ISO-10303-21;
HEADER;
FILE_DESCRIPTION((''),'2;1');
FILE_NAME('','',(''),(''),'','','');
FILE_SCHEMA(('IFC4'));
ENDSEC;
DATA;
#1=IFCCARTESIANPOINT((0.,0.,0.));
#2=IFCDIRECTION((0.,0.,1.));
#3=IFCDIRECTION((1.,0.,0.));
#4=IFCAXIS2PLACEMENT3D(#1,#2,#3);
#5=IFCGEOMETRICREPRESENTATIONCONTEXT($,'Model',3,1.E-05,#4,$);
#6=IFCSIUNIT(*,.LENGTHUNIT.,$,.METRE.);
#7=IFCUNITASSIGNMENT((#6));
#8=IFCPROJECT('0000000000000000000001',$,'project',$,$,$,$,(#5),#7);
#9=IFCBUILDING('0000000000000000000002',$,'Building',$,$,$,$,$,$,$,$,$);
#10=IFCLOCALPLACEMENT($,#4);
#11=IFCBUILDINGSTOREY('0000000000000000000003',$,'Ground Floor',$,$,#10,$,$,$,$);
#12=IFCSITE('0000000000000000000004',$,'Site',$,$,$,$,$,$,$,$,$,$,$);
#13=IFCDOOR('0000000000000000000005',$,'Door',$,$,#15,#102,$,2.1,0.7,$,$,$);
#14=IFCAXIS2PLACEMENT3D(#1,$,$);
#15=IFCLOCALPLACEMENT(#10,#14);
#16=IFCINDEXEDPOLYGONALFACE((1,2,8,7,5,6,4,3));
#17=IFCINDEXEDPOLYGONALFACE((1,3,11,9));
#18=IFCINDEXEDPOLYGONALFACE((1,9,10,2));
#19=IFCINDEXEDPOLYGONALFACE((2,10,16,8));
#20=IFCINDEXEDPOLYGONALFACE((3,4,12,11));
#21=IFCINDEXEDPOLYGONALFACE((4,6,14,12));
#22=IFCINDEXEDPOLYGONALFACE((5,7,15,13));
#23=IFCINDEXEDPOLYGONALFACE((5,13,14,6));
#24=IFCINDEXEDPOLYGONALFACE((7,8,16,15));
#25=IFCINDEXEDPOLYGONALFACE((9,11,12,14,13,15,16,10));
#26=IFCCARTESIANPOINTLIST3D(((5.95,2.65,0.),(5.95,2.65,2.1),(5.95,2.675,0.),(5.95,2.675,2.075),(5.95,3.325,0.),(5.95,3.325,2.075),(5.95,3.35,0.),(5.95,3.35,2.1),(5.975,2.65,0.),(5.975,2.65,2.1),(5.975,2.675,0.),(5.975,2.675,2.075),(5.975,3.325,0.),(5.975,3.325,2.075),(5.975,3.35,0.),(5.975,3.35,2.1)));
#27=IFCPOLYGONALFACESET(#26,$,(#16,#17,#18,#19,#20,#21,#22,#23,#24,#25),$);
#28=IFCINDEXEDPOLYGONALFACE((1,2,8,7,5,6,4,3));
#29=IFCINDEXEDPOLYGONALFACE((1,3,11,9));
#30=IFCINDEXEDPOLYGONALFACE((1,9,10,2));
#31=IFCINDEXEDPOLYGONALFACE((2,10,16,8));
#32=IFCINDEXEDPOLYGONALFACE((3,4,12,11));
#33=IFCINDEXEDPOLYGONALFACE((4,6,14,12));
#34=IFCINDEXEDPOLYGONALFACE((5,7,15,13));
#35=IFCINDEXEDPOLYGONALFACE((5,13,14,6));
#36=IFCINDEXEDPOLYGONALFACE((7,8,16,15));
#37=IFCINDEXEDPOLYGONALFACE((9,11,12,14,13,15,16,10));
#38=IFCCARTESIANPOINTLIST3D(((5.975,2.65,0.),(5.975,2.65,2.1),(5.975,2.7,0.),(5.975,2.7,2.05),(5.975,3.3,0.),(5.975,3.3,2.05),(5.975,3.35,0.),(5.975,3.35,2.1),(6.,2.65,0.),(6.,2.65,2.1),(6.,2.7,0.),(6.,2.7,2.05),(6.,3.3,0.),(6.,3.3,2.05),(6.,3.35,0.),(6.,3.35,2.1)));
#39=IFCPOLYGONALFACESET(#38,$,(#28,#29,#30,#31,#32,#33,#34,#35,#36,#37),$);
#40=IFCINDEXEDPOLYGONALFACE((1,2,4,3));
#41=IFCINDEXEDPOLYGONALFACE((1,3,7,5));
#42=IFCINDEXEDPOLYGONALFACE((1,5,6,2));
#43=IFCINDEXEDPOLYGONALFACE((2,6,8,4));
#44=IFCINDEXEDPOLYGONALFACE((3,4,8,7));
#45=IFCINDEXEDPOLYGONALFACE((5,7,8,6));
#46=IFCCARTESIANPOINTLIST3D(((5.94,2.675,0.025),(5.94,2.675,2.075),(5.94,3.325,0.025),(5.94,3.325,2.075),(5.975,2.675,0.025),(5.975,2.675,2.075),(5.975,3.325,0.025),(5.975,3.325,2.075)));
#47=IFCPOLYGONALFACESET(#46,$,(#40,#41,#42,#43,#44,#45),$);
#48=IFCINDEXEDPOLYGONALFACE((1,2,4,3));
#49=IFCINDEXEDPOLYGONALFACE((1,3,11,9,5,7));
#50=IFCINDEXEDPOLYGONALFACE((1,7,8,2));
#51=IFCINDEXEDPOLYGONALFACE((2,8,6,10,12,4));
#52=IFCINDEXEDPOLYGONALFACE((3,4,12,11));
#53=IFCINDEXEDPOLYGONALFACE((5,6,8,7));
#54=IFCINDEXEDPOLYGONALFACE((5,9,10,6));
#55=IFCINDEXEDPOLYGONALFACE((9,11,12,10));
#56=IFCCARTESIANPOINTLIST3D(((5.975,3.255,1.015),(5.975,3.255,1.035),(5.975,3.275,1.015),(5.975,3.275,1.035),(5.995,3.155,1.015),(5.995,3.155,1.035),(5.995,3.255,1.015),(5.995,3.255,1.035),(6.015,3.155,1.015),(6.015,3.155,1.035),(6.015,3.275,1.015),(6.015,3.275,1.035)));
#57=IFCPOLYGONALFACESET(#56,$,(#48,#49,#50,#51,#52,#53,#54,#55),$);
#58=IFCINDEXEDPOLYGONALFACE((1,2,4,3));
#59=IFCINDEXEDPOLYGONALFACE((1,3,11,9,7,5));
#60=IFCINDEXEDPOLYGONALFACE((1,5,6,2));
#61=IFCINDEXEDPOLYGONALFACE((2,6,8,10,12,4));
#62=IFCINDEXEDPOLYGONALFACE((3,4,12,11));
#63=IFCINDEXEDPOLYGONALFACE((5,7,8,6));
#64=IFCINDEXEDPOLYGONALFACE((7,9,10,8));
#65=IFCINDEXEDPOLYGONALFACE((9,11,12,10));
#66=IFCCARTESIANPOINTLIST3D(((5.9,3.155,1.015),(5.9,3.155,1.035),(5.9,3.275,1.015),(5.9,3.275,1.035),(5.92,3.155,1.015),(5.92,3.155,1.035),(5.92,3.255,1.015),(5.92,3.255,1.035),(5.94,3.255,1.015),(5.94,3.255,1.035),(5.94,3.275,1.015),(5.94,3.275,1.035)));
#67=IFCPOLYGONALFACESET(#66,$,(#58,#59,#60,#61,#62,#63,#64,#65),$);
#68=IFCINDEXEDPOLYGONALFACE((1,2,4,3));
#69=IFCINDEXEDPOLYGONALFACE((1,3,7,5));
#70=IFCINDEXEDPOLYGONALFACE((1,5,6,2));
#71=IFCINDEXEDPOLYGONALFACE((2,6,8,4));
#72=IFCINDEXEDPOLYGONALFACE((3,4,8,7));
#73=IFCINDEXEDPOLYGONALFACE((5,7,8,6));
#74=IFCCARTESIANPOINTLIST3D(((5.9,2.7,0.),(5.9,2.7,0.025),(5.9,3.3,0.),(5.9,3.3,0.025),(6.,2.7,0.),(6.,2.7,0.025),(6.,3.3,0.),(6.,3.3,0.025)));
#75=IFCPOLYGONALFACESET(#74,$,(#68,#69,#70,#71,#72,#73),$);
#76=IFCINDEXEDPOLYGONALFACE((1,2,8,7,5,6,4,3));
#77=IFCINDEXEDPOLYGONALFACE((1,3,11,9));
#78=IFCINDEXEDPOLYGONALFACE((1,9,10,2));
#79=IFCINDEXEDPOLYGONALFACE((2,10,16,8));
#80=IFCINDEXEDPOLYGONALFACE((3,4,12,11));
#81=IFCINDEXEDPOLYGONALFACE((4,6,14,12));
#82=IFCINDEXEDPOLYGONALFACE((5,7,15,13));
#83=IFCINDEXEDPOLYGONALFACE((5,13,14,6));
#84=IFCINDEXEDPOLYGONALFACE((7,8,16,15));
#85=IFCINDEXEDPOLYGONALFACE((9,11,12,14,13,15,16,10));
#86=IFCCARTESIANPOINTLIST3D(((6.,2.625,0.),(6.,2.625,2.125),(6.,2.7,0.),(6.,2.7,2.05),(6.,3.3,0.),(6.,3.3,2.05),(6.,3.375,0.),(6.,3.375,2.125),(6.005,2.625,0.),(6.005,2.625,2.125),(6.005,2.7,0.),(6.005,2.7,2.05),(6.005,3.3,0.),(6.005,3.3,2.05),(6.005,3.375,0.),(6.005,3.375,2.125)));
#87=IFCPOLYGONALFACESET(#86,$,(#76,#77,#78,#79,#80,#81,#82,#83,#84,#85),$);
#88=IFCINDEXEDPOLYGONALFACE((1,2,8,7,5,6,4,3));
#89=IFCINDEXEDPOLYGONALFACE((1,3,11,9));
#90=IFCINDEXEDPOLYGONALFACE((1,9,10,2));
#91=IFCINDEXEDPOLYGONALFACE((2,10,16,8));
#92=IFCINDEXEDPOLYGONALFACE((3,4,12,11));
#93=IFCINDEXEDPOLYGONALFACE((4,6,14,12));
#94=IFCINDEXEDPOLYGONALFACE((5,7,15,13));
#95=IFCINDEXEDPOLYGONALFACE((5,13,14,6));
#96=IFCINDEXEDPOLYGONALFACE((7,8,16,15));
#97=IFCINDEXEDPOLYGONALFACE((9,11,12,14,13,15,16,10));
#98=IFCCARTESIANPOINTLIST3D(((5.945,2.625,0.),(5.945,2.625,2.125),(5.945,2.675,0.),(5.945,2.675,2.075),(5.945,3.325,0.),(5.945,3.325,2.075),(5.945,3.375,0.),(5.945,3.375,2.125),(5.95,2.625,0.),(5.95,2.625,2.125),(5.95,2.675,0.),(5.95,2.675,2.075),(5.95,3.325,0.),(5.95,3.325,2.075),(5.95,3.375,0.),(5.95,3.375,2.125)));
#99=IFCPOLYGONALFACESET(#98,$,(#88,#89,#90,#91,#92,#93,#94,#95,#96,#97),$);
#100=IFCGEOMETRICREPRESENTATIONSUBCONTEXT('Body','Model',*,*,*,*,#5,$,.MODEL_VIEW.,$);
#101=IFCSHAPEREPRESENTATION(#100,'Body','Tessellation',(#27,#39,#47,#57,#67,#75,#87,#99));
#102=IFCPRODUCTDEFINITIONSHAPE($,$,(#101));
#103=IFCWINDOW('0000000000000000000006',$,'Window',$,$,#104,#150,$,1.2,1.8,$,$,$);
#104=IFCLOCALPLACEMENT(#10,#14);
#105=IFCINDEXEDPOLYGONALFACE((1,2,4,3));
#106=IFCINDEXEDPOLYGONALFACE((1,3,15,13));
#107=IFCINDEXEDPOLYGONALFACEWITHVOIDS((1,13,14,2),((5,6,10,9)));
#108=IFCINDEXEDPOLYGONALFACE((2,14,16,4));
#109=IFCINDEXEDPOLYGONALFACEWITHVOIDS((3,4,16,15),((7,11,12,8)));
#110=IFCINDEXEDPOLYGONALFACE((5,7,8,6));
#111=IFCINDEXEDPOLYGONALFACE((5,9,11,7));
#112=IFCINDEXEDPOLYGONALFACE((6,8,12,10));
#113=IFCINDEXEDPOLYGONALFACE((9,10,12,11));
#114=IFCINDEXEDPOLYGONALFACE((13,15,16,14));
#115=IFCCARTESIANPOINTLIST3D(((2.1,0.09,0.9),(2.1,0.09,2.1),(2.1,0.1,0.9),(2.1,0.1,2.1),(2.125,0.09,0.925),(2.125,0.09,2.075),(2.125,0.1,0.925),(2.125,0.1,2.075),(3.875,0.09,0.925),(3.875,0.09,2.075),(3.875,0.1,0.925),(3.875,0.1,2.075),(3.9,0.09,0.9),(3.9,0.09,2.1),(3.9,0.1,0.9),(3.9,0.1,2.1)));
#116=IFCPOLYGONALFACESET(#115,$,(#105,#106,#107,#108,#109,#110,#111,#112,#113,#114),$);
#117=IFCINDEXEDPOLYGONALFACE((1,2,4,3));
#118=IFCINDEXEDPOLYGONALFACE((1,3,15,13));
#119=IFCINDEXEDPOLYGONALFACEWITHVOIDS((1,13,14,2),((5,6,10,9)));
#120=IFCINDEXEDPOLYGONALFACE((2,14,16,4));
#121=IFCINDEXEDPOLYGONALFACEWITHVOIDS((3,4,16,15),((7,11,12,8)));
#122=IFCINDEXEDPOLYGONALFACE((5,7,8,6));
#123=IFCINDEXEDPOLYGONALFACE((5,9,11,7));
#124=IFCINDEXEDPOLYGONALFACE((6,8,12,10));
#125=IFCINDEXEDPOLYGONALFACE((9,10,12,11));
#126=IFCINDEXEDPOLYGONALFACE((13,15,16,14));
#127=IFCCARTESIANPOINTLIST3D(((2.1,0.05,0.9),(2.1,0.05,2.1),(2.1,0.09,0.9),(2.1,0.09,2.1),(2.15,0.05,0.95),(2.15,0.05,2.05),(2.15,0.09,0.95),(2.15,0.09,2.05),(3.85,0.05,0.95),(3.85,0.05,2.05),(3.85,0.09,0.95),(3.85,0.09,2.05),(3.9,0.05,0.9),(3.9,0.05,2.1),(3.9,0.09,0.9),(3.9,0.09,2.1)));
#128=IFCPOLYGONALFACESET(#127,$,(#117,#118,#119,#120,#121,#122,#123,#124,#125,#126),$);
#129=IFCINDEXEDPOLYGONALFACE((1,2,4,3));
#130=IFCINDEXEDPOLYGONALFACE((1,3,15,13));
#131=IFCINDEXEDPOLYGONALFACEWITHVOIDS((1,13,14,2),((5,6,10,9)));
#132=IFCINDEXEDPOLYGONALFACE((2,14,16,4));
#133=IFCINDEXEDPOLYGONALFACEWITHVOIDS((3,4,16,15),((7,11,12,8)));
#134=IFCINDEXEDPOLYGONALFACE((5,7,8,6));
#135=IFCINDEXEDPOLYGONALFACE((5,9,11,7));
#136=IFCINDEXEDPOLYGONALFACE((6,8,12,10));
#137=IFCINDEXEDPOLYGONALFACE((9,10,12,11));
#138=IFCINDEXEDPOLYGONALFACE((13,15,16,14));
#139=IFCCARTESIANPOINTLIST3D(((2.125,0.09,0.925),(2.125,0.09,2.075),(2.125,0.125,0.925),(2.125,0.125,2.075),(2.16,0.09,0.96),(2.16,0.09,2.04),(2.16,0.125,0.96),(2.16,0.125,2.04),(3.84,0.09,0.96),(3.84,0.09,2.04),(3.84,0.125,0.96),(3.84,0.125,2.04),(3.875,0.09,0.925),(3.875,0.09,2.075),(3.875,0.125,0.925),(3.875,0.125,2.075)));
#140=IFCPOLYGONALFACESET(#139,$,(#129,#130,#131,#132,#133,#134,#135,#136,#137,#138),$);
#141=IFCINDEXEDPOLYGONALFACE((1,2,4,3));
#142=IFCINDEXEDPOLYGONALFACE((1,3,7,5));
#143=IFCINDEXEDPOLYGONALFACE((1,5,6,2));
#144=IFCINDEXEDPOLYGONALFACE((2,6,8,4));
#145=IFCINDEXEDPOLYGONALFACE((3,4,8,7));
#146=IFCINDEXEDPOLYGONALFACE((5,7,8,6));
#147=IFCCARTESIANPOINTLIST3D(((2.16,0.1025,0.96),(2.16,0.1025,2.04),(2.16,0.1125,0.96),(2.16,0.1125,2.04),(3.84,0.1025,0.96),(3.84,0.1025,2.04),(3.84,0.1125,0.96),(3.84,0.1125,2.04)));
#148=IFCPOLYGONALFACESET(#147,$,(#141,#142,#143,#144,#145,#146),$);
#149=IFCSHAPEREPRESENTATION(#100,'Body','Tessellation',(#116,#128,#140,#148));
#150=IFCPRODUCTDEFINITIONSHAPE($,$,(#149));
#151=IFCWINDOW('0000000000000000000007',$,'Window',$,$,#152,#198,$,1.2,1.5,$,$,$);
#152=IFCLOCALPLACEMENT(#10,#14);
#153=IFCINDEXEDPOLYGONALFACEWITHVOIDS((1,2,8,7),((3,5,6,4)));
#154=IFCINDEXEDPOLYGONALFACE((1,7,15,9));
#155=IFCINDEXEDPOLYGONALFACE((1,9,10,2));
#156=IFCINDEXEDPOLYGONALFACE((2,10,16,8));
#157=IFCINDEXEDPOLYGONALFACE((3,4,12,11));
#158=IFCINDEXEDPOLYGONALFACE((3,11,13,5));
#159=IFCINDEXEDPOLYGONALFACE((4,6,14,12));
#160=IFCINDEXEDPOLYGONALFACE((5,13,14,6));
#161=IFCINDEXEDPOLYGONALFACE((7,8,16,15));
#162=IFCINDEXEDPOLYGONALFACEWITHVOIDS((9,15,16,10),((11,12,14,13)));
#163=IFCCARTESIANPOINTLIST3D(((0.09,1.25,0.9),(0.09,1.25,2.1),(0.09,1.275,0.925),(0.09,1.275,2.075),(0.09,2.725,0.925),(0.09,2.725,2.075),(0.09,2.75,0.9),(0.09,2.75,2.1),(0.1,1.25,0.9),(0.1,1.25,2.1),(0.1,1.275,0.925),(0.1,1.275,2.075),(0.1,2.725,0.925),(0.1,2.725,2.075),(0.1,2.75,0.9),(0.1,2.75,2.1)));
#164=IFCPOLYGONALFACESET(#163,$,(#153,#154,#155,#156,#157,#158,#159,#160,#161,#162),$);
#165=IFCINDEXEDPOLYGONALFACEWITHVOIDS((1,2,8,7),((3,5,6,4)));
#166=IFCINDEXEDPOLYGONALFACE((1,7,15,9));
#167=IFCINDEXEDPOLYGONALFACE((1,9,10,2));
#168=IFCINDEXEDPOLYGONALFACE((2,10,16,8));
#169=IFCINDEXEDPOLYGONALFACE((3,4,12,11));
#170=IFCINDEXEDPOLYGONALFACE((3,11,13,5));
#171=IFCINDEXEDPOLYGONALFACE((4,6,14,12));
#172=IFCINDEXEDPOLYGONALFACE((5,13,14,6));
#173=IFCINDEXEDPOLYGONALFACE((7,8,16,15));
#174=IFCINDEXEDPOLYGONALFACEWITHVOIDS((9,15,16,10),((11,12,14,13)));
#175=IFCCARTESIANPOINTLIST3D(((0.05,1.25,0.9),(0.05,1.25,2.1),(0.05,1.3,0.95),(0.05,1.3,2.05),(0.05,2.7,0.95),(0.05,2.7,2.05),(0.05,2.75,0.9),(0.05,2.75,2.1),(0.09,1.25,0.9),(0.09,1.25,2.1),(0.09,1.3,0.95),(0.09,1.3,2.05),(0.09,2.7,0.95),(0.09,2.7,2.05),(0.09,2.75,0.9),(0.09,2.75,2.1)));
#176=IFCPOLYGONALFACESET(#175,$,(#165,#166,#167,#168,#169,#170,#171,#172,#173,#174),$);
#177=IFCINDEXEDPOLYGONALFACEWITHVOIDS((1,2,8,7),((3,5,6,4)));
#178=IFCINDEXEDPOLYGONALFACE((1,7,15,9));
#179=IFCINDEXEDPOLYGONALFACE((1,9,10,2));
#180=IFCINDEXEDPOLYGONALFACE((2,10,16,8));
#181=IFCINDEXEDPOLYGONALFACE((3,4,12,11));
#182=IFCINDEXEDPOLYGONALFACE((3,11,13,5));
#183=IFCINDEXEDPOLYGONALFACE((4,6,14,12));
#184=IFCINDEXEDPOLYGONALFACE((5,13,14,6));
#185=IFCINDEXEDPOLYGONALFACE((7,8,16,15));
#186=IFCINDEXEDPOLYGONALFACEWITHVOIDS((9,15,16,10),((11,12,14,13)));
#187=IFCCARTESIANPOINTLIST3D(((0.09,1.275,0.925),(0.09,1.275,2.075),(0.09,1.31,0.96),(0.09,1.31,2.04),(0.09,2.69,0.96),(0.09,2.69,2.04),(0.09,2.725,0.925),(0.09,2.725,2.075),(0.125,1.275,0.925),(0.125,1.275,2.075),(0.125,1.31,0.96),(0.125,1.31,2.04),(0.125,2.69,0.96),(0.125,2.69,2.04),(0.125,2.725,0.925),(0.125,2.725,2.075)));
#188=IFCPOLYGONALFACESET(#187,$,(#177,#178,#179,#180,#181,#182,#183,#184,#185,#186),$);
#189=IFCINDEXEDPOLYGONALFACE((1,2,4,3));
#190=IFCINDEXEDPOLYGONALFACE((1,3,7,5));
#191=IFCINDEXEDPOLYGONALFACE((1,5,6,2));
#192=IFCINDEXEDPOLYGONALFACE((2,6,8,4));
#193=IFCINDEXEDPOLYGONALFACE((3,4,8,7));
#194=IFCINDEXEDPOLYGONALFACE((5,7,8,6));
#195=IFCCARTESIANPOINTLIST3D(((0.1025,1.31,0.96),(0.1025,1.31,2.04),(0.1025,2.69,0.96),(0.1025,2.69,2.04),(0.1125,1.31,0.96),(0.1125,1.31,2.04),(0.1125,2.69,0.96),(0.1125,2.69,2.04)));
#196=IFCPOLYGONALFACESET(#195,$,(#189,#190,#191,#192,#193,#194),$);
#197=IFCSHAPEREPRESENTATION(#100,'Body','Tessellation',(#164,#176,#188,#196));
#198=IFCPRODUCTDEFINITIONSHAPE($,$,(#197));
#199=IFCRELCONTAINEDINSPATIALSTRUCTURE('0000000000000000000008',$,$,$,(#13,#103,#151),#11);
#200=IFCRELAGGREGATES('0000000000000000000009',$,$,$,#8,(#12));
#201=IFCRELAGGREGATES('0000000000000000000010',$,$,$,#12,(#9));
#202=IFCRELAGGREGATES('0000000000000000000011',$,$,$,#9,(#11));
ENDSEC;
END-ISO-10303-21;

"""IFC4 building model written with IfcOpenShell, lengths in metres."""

from ifc_helpers import new_model, si_unit, frame, origin_with_axes, place, context, subcontext, project, spatial, line, indexed_curve, outline, extrude, element, save


model = new_model("IFC4")

# Units and contexts
model_context = context("Model", 3, precision=1e-05, world=origin_with_axes())
body_context = subcontext(model_context, "Body", "Model", "MODEL_VIEW")
ifc_project = project(units=[si_unit("LENGTHUNIT", "METRE")], contexts=[model_context])

# Site, building, storey
site = spatial("IfcSite", under=ifc_project, Name="Site")
building = spatial("IfcBuilding", under=site, Name="Building")
storey_placement = place(None, origin_with_axes())
storey = spatial("IfcBuildingStorey", under=building, at=storey_placement, Name="Ground Floor")

# Door
door_1_placement = place(storey_placement, frame((6.0, 2.65, 0.0), z_axis=(0.0, 0.0, 1.0), x_axis=(0.0, 1.0, 0.0)))
element("IfcDoor", 1, at=door_1_placement, inside=storey, Name="Door", OverallHeight=2.1, OverallWidth=0.7, context=body_context, shape_type="SweptSolid", body=[
    extrude(outline(indexed_curve([(0.0, 0.0), (0.0, 2.1), (0.7, 2.1), (0.7, 0.0), (0.675, 0.0), (0.675, 2.075), (0.025, 2.075), (0.025, 0.0)], segments=[line(1, 2, 3, 4, 5, 6, 7, 8, 1)])), frame((0.0, 0.025, 0.0), z_axis=(0.0, -1.0, 0.0), x_axis=(1.0, 0.0, 0.0)), (0.0, 0.0, -1.0), 0.025),
    extrude(outline(indexed_curve([(0.0, 0.0), (0.0, 2.1), (0.7, 2.1), (0.7, 0.0), (0.65, 0.0), (0.65, 2.05), (0.05, 2.05), (0.05, 0.0)], segments=[line(1, 2, 3, 4, 5, 6, 7, 8, 1)])), frame((0.0, 0.0, 0.0), z_axis=(0.0, -1.0, 0.0), x_axis=(1.0, 0.0, 0.0)), (0.0, 0.0, -1.0), 0.025),
    extrude(outline(indexed_curve([(0.0, 0.0), (0.65, 0.0), (0.65, 0.035), (0.0, 0.035)], segments=[line(1, 2, 3, 4, 1)])), frame((0.025, 0.025, 0.025), z_axis=(0.0, 0.0, 1.0), x_axis=(1.0, 0.0, 0.0)), (0.0, 0.0, 1.0), 2.05),
    extrude(outline(indexed_curve([(0.0, 0.0), (0.0, -0.04), (-0.12, -0.04), (-0.12, -0.02), (-0.02, -0.02), (-0.02, 0.0)], segments=[line(1, 2, 3, 4, 5, 6, 1)])), frame((0.625, 0.025, 1.015), z_axis=(0.0, 0.0, 1.0), x_axis=(1.0, 0.0, 0.0)), (0.0, 0.0, 1.0), 0.02),
    extrude(outline(indexed_curve([(0.0, 0.0), (0.0, 0.04), (-0.12, 0.04), (-0.12, 0.02), (-0.02, 0.02), (-0.02, 0.0)], segments=[line(1, 2, 3, 4, 5, 6, 1)])), frame((0.625, 0.06, 1.015), z_axis=(0.0, 0.0, 1.0), x_axis=(1.0, 0.0, 0.0)), (0.0, 0.0, 1.0), 0.02),
    extrude(outline(indexed_curve([(0.0, 0.0), (0.6, 0.0), (0.6, 0.1), (0.0, 0.1)], segments=[line(1, 2, 3, 4, 1)])), frame((0.05, 0.0, 0.0), z_axis=(0.0, 0.0, 1.0), x_axis=(1.0, 0.0, 0.0)), (0.0, 0.0, 1.0), 0.025),
    extrude(outline(indexed_curve([(0.0, 0.0), (0.0, 2.125), (0.75, 2.125), (0.75, 0.0), (0.675, 0.0), (0.675, 2.05), (0.075, 2.05), (0.075, 0.0)], segments=[line(1, 2, 3, 4, 5, 6, 7, 8, 1)])), frame((-0.025, -0.005, 0.0), z_axis=(0.0, -1.0, 0.0), x_axis=(1.0, 0.0, 0.0)), (0.0, 0.0, -1.0), 0.005),
    extrude(outline(indexed_curve([(0.0, 0.0), (0.0, 2.125), (0.75, 2.125), (0.75, 0.0), (0.7, 0.0), (0.7, 2.075), (0.05, 2.075), (0.05, 0.0)], segments=[line(1, 2, 3, 4, 5, 6, 7, 8, 1)])), frame((-0.025, 0.05, 0.0), z_axis=(0.0, -1.0, 0.0), x_axis=(1.0, 0.0, 0.0)), (0.0, 0.0, -1.0), 0.005),
])

# Windows
window_1_placement = place(storey_placement, frame((2.1, 0.0, 0.9), z_axis=(0.0, 0.0, 1.0), x_axis=(1.0, 0.0, 0.0)))
element("IfcWindow", 2, at=window_1_placement, inside=storey, Name="Window", OverallHeight=1.2, OverallWidth=1.8, context=body_context, shape_type="SweptSolid", body=[
    extrude(outline(indexed_curve([(0.0, 0.0), (1.8, 0.0), (1.8, 1.2), (0.0, 1.2)], segments=[line(1, 2, 3, 4, 1)]), holes=[indexed_curve([(0.025, 0.025), (1.775, 0.025), (1.775, 1.175), (0.025, 1.175)], segments=[line(1, 2, 3, 4, 1)])]), frame((0.0, 0.09, 0.0), z_axis=(0.0, -1.0, 0.0), x_axis=(1.0, 0.0, 0.0)), (0.0, 0.0, -1.0), 0.01),
    extrude(outline(indexed_curve([(0.0, 0.0), (1.8, 0.0), (1.8, 1.2), (0.0, 1.2)], segments=[line(1, 2, 3, 4, 1)]), holes=[indexed_curve([(0.05, 0.05), (1.75, 0.05), (1.75, 1.15), (0.05, 1.15)], segments=[line(1, 2, 3, 4, 1)])]), frame((0.0, 0.05, 0.0), z_axis=(0.0, -1.0, 0.0), x_axis=(1.0, 0.0, 0.0)), (0.0, 0.0, -1.0), 0.04),
    extrude(outline(indexed_curve([(0.0, 0.0), (1.75, 0.0), (1.75, 1.15), (0.0, 1.15)], segments=[line(1, 2, 3, 4, 1)]), holes=[indexed_curve([(0.035, 0.035), (1.715, 0.035), (1.715, 1.115), (0.035, 1.115)], segments=[line(1, 2, 3, 4, 1)])]), frame((0.025, 0.09, 0.025), z_axis=(0.0, -1.0, 0.0), x_axis=(1.0, 0.0, 0.0)), (0.0, 0.0, -1.0), 0.035),
    extrude(outline(indexed_curve([(0.035, 0.035), (1.715, 0.035), (1.715, 1.115), (0.035, 1.115)], segments=[line(1, 2, 3, 4, 1)])), frame((0.025, 0.1025, 0.025), z_axis=(0.0, -1.0, 0.0), x_axis=(1.0, 0.0, 0.0)), (0.0, 0.0, -1.0), 0.01),
])
for number, where, z_axis, x_axis, name in (
    (3, (0.0, 2.75, 0.9), (0.0, 0.0, 1.0), (0.0, -1.0, 0.0), "Window"),
):
    element("IfcWindow", number, at=place(storey_placement, frame(where, z_axis=z_axis, x_axis=x_axis)), inside=storey, Name=name, OverallHeight=1.2, OverallWidth=1.5, context=body_context, shape_type="SweptSolid", body=[
        extrude(outline(indexed_curve([(0.0, 0.0), (1.5, 0.0), (1.5, 1.2), (0.0, 1.2)], segments=[line(1, 2, 3, 4, 1)]), holes=[indexed_curve([(0.025, 0.025), (1.475, 0.025), (1.475, 1.175), (0.025, 1.175)], segments=[line(1, 2, 3, 4, 1)])]), frame((0.0, 0.09, 0.0), z_axis=(0.0, -1.0, 0.0), x_axis=(1.0, 0.0, 0.0)), (0.0, 0.0, -1.0), 0.01),
        extrude(outline(indexed_curve([(0.0, 0.0), (1.5, 0.0), (1.5, 1.2), (0.0, 1.2)], segments=[line(1, 2, 3, 4, 1)]), holes=[indexed_curve([(0.05, 0.05), (1.45, 0.05), (1.45, 1.15), (0.05, 1.15)], segments=[line(1, 2, 3, 4, 1)])]), frame((0.0, 0.05, 0.0), z_axis=(0.0, -1.0, 0.0), x_axis=(1.0, 0.0, 0.0)), (0.0, 0.0, -1.0), 0.04),
        extrude(outline(indexed_curve([(0.0, 0.0), (1.45, 0.0), (1.45, 1.15), (0.0, 1.15)], segments=[line(1, 2, 3, 4, 1)]), holes=[indexed_curve([(0.035, 0.035), (1.415, 0.035), (1.415, 1.115), (0.035, 1.115)], segments=[line(1, 2, 3, 4, 1)])]), frame((0.025, 0.09, 0.025), z_axis=(0.0, -1.0, 0.0), x_axis=(1.0, 0.0, 0.0)), (0.0, 0.0, -1.0), 0.035),
        extrude(outline(indexed_curve([(0.035, 0.035), (1.415, 0.035), (1.415, 1.115), (0.035, 1.115)], segments=[line(1, 2, 3, 4, 1)])), frame((0.025, 0.1025, 0.025), z_axis=(0.0, -1.0, 0.0), x_axis=(1.0, 0.0, 0.0)), (0.0, 0.0, -1.0), 0.01),
    ])

save(model, "model.ifc")
